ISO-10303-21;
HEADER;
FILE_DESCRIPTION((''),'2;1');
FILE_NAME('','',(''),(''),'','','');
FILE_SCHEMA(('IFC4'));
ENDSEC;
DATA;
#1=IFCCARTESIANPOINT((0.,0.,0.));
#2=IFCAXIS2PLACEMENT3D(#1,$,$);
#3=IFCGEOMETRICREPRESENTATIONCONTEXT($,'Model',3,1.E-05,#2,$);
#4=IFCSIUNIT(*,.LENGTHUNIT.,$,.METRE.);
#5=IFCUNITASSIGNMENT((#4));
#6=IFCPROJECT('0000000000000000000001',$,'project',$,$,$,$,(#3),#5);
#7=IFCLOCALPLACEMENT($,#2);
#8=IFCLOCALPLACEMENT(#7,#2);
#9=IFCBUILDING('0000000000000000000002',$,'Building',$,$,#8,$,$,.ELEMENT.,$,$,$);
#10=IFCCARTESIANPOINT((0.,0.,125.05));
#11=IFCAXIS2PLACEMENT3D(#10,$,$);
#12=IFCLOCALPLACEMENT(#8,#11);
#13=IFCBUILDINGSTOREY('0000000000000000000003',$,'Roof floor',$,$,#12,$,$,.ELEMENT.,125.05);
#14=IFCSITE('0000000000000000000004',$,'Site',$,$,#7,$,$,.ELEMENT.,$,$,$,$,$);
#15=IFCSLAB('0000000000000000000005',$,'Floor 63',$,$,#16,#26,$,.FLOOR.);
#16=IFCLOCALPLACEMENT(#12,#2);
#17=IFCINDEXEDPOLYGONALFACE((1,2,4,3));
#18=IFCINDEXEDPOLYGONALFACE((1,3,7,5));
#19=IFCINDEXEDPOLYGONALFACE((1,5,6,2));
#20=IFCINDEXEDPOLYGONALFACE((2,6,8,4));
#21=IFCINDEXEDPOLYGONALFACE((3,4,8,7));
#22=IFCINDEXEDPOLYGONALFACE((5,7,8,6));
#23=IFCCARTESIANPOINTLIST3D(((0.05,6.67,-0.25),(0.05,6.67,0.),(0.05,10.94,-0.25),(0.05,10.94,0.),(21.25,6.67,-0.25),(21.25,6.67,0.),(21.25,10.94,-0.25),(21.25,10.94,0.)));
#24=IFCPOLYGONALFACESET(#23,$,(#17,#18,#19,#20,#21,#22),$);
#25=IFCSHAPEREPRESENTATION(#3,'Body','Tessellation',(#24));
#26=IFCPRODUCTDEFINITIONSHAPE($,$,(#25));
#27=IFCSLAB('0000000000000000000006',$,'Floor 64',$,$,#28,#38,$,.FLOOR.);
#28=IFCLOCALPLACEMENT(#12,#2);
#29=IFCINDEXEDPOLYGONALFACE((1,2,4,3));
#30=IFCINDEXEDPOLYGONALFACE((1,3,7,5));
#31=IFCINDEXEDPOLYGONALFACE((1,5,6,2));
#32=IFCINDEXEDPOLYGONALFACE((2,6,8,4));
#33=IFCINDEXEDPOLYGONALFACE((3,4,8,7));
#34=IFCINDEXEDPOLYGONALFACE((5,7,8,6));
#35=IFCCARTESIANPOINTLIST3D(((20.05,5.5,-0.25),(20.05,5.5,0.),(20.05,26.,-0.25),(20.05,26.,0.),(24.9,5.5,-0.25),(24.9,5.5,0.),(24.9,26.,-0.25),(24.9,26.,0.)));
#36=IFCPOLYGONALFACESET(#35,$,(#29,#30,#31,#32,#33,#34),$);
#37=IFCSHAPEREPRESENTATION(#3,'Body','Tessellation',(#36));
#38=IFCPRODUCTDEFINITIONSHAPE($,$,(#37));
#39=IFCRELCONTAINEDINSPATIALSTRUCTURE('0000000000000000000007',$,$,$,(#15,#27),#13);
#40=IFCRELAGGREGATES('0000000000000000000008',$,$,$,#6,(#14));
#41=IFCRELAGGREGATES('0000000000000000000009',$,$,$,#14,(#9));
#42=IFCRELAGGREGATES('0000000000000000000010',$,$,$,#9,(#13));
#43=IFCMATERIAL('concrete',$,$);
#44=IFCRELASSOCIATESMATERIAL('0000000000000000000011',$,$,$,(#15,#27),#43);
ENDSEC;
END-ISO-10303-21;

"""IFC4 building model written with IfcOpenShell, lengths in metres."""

from ifc_helpers import new_model, si_unit, frame, origin, place, context, project, spatial, polyline, outline, extrude, material, element, save


model = new_model("IFC4")

# Units and contexts
model_context = context("Model", 3, precision=1e-05, world=origin())
ifc_project = project(units=[si_unit("LENGTHUNIT", "METRE")], contexts=[model_context])

# Site, building, storey
site_placement = place(None, origin())
site = spatial("IfcSite", under=ifc_project, at=site_placement, Name="Site", CompositionType="ELEMENT")
building_placement = place(site_placement, origin())
building = spatial("IfcBuilding", under=site, at=building_placement, Name="Building", CompositionType="ELEMENT")
storey_placement = place(building_placement, frame((0.0, 0.0, 125.05)))
storey = spatial("IfcBuildingStorey", under=building, at=storey_placement, Name="Roof floor", CompositionType="ELEMENT", Elevation=125.05)

# Slabs
ifc_material = material(Name="concrete")
slab_1_placement = place(storey_placement, frame((0.0, 0.0, -0.25), z_axis=(0.0, 0.0, 1.0), x_axis=(1.0, 0.0, 0.0)))
element("IfcSlab", 1, at=slab_1_placement, inside=storey, material=ifc_material, Name="Floor 63", PredefinedType="FLOOR", context=model_context, shape_type="SweptSolid", body=[
    extrude(outline(polyline([(0.05, 6.67), (21.25, 6.67), (21.25, 10.94), (0.05, 10.94), (0.05, 6.67)])), origin(), (0.0, 0.0, 1.0), 0.25),
])
slab_2_placement = place(storey_placement, frame((0.0, 0.0, -0.25), z_axis=(0.0, 0.0, 1.0), x_axis=(1.0, 0.0, 0.0)))
element("IfcSlab", 2, at=slab_2_placement, inside=storey, material=ifc_material, Name="Floor 64", PredefinedType="FLOOR", context=model_context, shape_type="SweptSolid", body=[
    extrude(outline(polyline([(20.05, 5.5), (24.9, 5.5), (24.9, 26.0), (20.05, 26.0), (20.05, 5.5)])), origin(), (0.0, 0.0, 1.0), 0.25),
])

save(model, "model.ifc")
